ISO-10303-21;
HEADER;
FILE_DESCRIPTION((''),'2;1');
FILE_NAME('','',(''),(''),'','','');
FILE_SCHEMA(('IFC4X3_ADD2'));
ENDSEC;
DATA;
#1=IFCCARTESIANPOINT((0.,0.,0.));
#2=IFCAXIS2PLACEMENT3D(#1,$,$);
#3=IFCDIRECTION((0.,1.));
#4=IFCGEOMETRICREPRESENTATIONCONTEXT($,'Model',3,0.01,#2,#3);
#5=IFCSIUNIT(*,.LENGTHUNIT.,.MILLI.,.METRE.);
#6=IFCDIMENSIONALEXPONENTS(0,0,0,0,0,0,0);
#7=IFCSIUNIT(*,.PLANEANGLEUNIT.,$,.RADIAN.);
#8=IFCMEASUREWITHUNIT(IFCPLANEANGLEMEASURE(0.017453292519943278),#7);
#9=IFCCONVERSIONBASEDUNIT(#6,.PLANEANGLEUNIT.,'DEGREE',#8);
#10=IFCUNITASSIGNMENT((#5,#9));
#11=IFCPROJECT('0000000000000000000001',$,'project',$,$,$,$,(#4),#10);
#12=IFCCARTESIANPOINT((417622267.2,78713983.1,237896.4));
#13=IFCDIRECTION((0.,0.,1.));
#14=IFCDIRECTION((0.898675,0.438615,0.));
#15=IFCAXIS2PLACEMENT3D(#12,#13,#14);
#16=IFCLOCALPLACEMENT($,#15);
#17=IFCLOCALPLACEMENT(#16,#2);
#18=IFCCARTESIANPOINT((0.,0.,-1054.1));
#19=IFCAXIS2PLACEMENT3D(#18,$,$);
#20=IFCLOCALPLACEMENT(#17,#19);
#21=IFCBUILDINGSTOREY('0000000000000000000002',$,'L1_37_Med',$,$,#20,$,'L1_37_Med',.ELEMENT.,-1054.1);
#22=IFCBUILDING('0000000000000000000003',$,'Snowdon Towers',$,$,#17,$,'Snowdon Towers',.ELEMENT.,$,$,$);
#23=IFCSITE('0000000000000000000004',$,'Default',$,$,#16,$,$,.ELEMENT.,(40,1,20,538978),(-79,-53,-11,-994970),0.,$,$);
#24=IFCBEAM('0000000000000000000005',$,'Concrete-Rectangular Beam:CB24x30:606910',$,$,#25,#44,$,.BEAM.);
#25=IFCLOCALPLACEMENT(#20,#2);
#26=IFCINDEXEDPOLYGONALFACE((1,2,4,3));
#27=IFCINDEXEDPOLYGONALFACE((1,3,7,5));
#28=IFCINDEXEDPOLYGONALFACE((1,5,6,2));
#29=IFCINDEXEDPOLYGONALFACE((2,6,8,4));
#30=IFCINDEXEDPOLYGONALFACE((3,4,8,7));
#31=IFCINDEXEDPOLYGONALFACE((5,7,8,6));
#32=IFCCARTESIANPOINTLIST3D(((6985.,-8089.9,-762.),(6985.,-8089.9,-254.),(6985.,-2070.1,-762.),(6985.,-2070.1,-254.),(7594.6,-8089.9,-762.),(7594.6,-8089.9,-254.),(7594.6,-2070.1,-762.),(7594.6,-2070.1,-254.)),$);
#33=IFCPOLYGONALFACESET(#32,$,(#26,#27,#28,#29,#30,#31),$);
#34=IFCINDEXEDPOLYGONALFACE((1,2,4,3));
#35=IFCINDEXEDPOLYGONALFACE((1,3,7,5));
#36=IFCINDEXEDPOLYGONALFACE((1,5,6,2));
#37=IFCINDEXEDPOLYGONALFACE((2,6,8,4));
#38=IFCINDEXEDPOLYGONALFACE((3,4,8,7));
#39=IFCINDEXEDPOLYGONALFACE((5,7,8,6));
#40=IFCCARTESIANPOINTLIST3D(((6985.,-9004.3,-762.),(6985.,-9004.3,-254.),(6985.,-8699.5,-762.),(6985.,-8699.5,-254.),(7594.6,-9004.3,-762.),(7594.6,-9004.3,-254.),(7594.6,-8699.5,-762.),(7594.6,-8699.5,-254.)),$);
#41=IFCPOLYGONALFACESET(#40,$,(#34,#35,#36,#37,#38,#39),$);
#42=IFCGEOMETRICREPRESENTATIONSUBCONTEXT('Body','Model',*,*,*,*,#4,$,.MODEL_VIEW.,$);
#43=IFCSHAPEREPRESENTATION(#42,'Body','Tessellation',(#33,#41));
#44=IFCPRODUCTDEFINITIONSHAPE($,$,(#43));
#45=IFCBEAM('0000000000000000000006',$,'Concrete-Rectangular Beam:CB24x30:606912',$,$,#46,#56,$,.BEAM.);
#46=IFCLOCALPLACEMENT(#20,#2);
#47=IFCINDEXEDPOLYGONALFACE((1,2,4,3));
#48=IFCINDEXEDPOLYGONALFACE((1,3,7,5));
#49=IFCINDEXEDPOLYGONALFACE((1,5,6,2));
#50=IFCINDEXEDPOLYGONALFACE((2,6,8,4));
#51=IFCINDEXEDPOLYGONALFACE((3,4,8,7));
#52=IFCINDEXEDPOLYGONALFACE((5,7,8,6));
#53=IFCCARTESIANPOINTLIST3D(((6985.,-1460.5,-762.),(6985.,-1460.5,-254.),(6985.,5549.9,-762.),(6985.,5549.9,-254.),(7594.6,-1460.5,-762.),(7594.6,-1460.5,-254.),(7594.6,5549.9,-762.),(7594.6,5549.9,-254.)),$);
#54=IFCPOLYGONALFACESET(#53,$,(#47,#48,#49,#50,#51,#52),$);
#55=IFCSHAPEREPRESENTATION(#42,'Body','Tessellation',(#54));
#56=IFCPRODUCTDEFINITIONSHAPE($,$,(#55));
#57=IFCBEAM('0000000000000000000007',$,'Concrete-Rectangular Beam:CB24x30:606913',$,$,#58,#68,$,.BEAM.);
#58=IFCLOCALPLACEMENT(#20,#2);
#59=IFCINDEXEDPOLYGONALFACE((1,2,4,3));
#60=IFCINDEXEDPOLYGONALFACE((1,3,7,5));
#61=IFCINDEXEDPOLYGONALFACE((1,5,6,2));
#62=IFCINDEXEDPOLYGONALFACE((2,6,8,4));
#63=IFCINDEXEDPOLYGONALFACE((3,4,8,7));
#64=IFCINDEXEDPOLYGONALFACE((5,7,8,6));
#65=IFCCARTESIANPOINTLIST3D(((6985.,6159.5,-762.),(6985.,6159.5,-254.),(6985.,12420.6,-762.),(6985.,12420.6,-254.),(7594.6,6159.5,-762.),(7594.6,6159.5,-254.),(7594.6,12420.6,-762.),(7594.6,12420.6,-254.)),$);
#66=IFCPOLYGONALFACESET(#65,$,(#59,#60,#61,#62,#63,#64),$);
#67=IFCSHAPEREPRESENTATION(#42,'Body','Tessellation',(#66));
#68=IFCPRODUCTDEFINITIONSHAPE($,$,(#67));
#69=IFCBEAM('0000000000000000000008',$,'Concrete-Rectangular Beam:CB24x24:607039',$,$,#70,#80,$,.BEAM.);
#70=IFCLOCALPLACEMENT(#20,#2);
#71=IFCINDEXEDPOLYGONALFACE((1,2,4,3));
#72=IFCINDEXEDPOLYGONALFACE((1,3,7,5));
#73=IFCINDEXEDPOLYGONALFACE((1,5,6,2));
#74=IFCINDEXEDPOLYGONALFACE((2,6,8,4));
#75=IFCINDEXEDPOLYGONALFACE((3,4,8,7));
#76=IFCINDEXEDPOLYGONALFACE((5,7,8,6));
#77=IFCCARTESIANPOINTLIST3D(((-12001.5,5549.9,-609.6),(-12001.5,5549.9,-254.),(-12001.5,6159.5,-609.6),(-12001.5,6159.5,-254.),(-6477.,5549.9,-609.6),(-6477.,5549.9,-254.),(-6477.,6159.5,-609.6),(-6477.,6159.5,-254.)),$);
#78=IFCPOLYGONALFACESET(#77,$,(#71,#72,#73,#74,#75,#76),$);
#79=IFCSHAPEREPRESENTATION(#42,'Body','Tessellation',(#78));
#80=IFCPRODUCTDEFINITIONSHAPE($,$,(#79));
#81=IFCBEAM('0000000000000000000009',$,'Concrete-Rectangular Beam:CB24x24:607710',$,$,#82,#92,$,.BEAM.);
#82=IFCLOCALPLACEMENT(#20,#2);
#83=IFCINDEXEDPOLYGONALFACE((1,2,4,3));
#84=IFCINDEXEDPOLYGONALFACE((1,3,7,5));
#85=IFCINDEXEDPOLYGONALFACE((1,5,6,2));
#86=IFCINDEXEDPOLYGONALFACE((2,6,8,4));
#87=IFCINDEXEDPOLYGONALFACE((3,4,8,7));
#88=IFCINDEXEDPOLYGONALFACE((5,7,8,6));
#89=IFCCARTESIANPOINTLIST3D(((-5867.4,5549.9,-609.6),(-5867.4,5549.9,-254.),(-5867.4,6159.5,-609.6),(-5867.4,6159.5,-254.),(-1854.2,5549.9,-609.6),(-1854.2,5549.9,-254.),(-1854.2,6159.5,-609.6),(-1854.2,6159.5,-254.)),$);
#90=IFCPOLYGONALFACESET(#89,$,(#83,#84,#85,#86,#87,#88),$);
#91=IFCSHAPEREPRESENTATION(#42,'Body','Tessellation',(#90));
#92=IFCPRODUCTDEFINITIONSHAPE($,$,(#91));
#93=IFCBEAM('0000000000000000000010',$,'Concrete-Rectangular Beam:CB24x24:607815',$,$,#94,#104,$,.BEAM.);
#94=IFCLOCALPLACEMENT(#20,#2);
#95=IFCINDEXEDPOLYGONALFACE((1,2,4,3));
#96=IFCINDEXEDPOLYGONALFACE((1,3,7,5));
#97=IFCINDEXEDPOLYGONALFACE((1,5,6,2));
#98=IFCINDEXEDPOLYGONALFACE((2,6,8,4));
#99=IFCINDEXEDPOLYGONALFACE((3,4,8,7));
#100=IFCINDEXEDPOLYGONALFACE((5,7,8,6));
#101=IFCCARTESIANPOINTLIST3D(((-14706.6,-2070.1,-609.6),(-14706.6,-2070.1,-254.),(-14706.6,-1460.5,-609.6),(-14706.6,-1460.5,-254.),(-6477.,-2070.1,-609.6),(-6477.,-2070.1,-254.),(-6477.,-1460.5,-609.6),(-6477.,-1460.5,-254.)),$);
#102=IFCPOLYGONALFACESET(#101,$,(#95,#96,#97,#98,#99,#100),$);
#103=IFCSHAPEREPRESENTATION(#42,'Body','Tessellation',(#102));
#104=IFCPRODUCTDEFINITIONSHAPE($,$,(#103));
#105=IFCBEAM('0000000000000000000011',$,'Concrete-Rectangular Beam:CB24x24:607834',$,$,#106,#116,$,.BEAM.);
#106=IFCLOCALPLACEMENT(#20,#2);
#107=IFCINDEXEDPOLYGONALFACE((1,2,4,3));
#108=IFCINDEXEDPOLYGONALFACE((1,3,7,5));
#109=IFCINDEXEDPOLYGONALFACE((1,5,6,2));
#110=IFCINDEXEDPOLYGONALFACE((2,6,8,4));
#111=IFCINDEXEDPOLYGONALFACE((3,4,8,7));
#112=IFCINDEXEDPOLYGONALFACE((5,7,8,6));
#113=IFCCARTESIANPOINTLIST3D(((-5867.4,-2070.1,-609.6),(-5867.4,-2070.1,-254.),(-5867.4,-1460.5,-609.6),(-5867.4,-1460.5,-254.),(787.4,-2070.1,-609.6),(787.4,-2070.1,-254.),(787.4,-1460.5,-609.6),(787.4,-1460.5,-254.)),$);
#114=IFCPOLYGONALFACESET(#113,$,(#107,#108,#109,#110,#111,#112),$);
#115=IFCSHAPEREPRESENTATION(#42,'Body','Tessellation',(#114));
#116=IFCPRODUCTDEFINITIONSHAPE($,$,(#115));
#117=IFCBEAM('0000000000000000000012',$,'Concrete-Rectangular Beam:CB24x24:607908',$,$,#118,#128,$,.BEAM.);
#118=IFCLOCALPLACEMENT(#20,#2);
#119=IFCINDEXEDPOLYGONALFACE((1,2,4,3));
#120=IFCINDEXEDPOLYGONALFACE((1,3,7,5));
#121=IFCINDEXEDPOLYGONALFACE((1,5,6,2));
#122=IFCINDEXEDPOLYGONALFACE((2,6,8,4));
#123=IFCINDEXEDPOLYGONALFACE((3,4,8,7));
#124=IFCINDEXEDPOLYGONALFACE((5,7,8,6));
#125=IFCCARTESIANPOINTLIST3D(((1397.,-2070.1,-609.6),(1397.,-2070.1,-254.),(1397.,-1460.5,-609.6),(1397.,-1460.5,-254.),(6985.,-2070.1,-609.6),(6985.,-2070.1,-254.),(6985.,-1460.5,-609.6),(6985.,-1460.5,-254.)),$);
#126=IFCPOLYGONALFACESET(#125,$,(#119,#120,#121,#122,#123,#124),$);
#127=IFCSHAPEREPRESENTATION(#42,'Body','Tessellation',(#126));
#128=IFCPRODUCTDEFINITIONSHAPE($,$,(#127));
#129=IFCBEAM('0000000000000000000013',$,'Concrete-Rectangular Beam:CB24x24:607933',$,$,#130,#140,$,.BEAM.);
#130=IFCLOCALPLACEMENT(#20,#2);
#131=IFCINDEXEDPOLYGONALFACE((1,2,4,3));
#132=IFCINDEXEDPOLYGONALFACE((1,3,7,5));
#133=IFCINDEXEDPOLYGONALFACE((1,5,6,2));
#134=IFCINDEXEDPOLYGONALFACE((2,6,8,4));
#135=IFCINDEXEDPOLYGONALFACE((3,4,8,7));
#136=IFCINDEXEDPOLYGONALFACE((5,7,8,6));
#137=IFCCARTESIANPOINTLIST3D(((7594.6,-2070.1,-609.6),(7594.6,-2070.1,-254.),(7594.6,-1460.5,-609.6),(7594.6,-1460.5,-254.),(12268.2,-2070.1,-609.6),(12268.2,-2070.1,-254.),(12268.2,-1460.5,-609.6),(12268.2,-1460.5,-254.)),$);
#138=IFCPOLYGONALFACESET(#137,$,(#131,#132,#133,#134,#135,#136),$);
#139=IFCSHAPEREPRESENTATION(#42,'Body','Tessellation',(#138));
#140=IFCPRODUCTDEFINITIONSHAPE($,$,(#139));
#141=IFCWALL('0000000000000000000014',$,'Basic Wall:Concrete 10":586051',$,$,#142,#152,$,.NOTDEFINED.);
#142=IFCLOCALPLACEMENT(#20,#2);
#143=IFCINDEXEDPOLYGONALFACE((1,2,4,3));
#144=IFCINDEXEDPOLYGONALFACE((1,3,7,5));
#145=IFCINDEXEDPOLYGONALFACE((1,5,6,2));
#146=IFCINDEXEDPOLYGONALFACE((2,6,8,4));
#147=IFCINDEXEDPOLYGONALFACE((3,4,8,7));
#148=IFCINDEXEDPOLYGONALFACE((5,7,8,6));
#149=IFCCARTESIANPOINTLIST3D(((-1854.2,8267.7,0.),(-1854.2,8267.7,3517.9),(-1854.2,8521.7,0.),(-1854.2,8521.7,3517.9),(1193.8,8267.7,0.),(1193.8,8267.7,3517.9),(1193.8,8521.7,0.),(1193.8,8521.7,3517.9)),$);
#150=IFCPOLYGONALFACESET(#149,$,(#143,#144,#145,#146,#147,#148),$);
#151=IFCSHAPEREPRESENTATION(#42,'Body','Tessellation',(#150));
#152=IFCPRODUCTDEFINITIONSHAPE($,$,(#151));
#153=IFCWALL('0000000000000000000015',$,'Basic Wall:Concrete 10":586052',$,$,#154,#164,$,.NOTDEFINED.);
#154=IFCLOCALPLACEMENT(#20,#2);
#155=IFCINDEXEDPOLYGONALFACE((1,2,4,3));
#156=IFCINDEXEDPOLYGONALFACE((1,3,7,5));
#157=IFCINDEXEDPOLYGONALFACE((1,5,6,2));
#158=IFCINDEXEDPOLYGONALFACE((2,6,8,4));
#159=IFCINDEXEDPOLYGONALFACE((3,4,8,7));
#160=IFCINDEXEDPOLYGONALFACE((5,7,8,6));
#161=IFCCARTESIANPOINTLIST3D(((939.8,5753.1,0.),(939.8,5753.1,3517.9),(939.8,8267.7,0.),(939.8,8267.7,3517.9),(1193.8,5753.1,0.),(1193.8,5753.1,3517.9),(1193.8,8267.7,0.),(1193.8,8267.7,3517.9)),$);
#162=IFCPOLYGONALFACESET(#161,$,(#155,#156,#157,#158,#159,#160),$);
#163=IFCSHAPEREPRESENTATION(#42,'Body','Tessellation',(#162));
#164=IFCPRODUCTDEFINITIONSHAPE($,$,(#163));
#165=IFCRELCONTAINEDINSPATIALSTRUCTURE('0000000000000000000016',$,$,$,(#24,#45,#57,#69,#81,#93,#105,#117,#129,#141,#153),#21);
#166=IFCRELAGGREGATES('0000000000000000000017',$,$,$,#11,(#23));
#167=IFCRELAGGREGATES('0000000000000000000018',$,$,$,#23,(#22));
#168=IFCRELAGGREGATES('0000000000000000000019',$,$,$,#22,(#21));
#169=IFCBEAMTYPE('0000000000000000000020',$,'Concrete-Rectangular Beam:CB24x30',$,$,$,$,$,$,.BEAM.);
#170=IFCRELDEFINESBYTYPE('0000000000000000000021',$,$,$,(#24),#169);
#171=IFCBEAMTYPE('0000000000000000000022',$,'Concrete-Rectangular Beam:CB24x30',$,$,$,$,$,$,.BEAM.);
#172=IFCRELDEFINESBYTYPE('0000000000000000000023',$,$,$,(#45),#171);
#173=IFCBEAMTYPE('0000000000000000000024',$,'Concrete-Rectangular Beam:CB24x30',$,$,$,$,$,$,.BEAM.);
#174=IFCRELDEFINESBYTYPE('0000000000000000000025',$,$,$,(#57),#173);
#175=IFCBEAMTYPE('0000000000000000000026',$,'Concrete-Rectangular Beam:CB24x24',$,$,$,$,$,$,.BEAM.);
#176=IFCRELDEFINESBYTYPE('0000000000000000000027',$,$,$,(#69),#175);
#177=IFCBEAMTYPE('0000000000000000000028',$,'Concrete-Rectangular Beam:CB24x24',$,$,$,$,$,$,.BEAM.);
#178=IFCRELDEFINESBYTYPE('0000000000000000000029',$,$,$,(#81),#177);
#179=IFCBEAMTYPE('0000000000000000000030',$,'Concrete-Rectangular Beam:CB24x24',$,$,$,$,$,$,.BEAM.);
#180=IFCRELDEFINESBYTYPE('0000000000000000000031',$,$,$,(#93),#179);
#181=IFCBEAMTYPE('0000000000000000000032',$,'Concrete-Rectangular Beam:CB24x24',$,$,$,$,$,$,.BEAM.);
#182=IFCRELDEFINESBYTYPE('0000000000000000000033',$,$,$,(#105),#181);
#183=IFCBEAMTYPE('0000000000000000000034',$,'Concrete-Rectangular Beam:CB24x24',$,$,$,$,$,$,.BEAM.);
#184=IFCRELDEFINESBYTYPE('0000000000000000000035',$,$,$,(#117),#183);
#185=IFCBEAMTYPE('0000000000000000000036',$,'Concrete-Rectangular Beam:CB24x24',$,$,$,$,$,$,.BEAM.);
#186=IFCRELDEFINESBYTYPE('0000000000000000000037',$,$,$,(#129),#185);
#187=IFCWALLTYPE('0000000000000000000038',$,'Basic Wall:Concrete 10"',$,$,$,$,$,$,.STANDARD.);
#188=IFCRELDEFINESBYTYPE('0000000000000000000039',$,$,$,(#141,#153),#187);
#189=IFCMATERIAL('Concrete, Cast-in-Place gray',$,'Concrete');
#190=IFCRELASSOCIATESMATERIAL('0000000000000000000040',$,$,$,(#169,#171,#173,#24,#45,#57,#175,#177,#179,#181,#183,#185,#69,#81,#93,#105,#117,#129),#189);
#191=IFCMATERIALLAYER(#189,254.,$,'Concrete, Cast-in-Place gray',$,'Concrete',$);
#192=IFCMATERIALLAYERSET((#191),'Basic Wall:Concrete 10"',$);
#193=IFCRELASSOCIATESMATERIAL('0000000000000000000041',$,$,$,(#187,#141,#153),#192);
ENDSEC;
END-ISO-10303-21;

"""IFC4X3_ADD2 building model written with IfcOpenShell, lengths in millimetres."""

from ifc_helpers import new_model, entity, si_unit, converted_unit, direction, frame, frame_2d, origin, origin_2d_with_axis, place, context, subcontext, project, spatial, rectangle, extrude, source, transform, mapped, material, layer, layer_set, material_profile, profile_set, profile_usage, type_object, type_shapes, element, save


model = new_model("IFC4X3_ADD2")

# Units and contexts
model_context = context("Model", 3, precision=0.01, world=origin(), true_north=direction((0.0, 1.0)))
body_context = subcontext(model_context, "Body", "Model", "MODEL_VIEW")
ifc_project = project(units=[si_unit("LENGTHUNIT", "METRE", prefix="MILLI"), converted_unit("PLANEANGLEUNIT", "DEGREE", entity("IfcPlaneAngleMeasure", 0.017453292519943278), si_unit("PLANEANGLEUNIT", "RADIAN"), dimensions=[0, 0, 0, 0, 0, 0, 0])], contexts=[model_context])

# Site, building, storey
site_placement = place(None, frame((417622267.2, 78713983.1, 237896.4), z_axis=(0.0, 0.0, 1.0), x_axis=(0.898675, 0.438615, 0.0)))
site = spatial("IfcSite", under=ifc_project, at=site_placement, Name="Default", CompositionType="ELEMENT", RefLatitude=(40, 1, 20, 538978), RefLongitude=(-79, -53, -11, -994970), RefElevation=0.0)
building_placement = place(site_placement, origin())
building = spatial("IfcBuilding", under=site, at=building_placement, Name="Snowdon Towers", LongName="Snowdon Towers", CompositionType="ELEMENT")
storey_placement = place(building_placement, frame((0.0, 0.0, -1054.1)))
storey = spatial("IfcBuildingStorey", under=building, at=storey_placement, Name="L1_37_Med", LongName="L1_37_Med", CompositionType="ELEMENT", Elevation=-1054.1)

# Beams
ifc_material_1 = material(Name="Concrete, Cast-in-Place gray", Category="Concrete")
ifc_material_profile_1 = material_profile(ifc_material_1, rectangle(XDim=508.0, YDim=609.6, at=frame_2d((0.0, 0.0), x_axis=(0.0, 1.0))), Name="CB24x30")
ifc_profile_set_1 = profile_set([ifc_material_profile_1], Name="CB24x30")
ifc_profile_usage_1 = profile_usage(ifc_profile_set_1, cardinal=8)
beam_type_1 = type_object("IfcBeamType", Name="Concrete-Rectangular Beam:CB24x30", PredefinedType="BEAM", material=ifc_profile_set_1)
shared_shape_1 = source(origin(), body_context, "Body", "SweptSolid", [
    extrude(rectangle(XDim=508.0, YDim=609.6, at=frame_2d((0.0, 0.0), x_axis=(0.0, 1.0))), frame((7289.8, -8089.9, -1562.1), z_axis=(0.0, 1.0, 0.0), x_axis=(-1.0, 0.0, 0.0)), (0.0, 0.0, 1.0), 6019.8),
    extrude(rectangle(XDim=508.0, YDim=609.6, at=frame_2d((0.0, 0.0), x_axis=(0.0, 1.0))), frame((7289.8, -9004.3, -1562.1), z_axis=(0.0, 1.0, 0.0), x_axis=(-1.0, 0.0, 0.0)), (0.0, 0.0, 1.0), 304.8),
])
type_shapes(beam_type_1, [shared_shape_1])
beam_1_placement = place(storey_placement, frame((0.0, 0.0, 1054.1)))
element("IfcBeam", 1, at=beam_1_placement, inside=storey, type_object=beam_type_1, material=ifc_profile_usage_1, Name="Concrete-Rectangular Beam:CB24x30:606910", PredefinedType="BEAM", context=body_context, shape_type="MappedRepresentation", body=[
    mapped(shared_shape_1, transform((0.0, 0.0, 0.0), scale=1.0)),
])
beam_type_2 = type_object("IfcBeamType", Name="Concrete-Rectangular Beam:CB24x30", PredefinedType="BEAM", material=ifc_profile_set_1)
shared_shape_2 = source(origin(), body_context, "Body", "SweptSolid", [
    extrude(rectangle(XDim=508.0, YDim=609.6, at=frame_2d((0.0, 0.0), x_axis=(0.0, 1.0))), frame((7289.8, -1460.5, -1562.1), z_axis=(0.0, 1.0, 0.0), x_axis=(-1.0, 0.0, 0.0)), (0.0, 0.0, 1.0), 7010.4),
])
type_shapes(beam_type_2, [shared_shape_2])
beam_2_placement = place(storey_placement, frame((0.0, 0.0, 1054.1)))
element("IfcBeam", 2, at=beam_2_placement, inside=storey, type_object=beam_type_2, material=ifc_profile_usage_1, Name="Concrete-Rectangular Beam:CB24x30:606912", PredefinedType="BEAM", context=body_context, shape_type="MappedRepresentation", body=[
    mapped(shared_shape_2, transform((0.0, 0.0, 0.0), scale=1.0)),
])
beam_type_3 = type_object("IfcBeamType", Name="Concrete-Rectangular Beam:CB24x30", PredefinedType="BEAM", material=ifc_profile_set_1)
shared_shape_3 = source(origin(), body_context, "Body", "SweptSolid", [
    extrude(rectangle(XDim=508.0, YDim=609.6, at=frame_2d((0.0, 0.0), x_axis=(0.0, 1.0))), frame((7289.8, 6159.5, -1562.1), z_axis=(0.0, 1.0, 0.0), x_axis=(-1.0, 0.0, 0.0)), (0.0, 0.0, 1.0), 6261.1),
])
type_shapes(beam_type_3, [shared_shape_3])
beam_3_placement = place(storey_placement, frame((0.0, 0.0, 1054.1)))
element("IfcBeam", 3, at=beam_3_placement, inside=storey, type_object=beam_type_3, material=ifc_profile_usage_1, Name="Concrete-Rectangular Beam:CB24x30:606913", PredefinedType="BEAM", context=body_context, shape_type="MappedRepresentation", body=[
    mapped(shared_shape_3, transform((0.0, 0.0, 0.0), scale=1.0)),
])
ifc_material_profile_2 = material_profile(ifc_material_1, rectangle(XDim=355.6, YDim=609.6, at=frame_2d((0.0, 0.0), x_axis=(1.0, 0.0))), Name="CB24x24")
ifc_profile_set_2 = profile_set([ifc_material_profile_2], Name="CB24x24")
ifc_profile_usage_2 = profile_usage(ifc_profile_set_2, cardinal=8)
beam_type_4 = type_object("IfcBeamType", Name="Concrete-Rectangular Beam:CB24x24", PredefinedType="BEAM", material=ifc_profile_set_2)
shared_shape_4 = source(origin(), body_context, "Body", "SweptSolid", [
    extrude(rectangle(XDim=355.6, YDim=609.6, at=frame_2d((0.0, 0.0), x_axis=(1.0, 0.0))), frame((-12001.5, 5854.7, -1485.9), z_axis=(1.0, 0.0, 0.0), x_axis=(0.0, 0.0, -1.0)), (0.0, 0.0, 1.0), 5524.5),
])
type_shapes(beam_type_4, [shared_shape_4])
beam_4_placement = place(storey_placement, frame((0.0, 0.0, 1054.1)))
element("IfcBeam", 4, at=beam_4_placement, inside=storey, type_object=beam_type_4, material=ifc_profile_usage_2, Name="Concrete-Rectangular Beam:CB24x24:607039", PredefinedType="BEAM", context=body_context, shape_type="MappedRepresentation", body=[
    mapped(shared_shape_4, transform((0.0, 0.0, 0.0), scale=1.0)),
])
beam_type_5 = type_object("IfcBeamType", Name="Concrete-Rectangular Beam:CB24x24", PredefinedType="BEAM", material=ifc_profile_set_2)
shared_shape_5 = source(origin(), body_context, "Body", "SweptSolid", [
    extrude(rectangle(XDim=355.6, YDim=609.6, at=origin_2d_with_axis()), frame((-5867.4, 5854.7, -1485.9), z_axis=(1.0, 0.0, 0.0), x_axis=(0.0, 0.0, -1.0)), (0.0, 0.0, 1.0), 4013.2),
])
type_shapes(beam_type_5, [shared_shape_5])
beam_5_placement = place(storey_placement, frame((0.0, 0.0, 1054.1)))
element("IfcBeam", 5, at=beam_5_placement, inside=storey, type_object=beam_type_5, material=ifc_profile_usage_2, Name="Concrete-Rectangular Beam:CB24x24:607710", PredefinedType="BEAM", context=body_context, shape_type="MappedRepresentation", body=[
    mapped(shared_shape_5, transform((0.0, 0.0, 0.0), scale=1.0)),
])
beam_type_6 = type_object("IfcBeamType", Name="Concrete-Rectangular Beam:CB24x24", PredefinedType="BEAM", material=ifc_profile_set_2)
shared_shape_6 = source(origin(), body_context, "Body", "SweptSolid", [
    extrude(rectangle(XDim=355.6, YDim=609.6, at=frame_2d((0.0, 0.0), x_axis=(1.0, 0.0))), frame((-14706.6, -1765.3, -1485.9), z_axis=(1.0, 0.0, 0.0), x_axis=(0.0, 0.0, -1.0)), (0.0, 0.0, 1.0), 8229.6),
])
type_shapes(beam_type_6, [shared_shape_6])
beam_6_placement = place(storey_placement, frame((0.0, 0.0, 1054.1)))
element("IfcBeam", 6, at=beam_6_placement, inside=storey, type_object=beam_type_6, material=ifc_profile_usage_2, Name="Concrete-Rectangular Beam:CB24x24:607815", PredefinedType="BEAM", context=body_context, shape_type="MappedRepresentation", body=[
    mapped(shared_shape_6, transform((0.0, 0.0, 0.0), scale=1.0)),
])
beam_type_7 = type_object("IfcBeamType", Name="Concrete-Rectangular Beam:CB24x24", PredefinedType="BEAM", material=ifc_profile_set_2)
shared_shape_7 = source(origin(), body_context, "Body", "SweptSolid", [
    extrude(rectangle(XDim=355.6, YDim=609.6, at=origin_2d_with_axis()), frame((-5867.4, -1765.3, -1485.9), z_axis=(1.0, 0.0, 0.0), x_axis=(0.0, 0.0, -1.0)), (0.0, 0.0, 1.0), 6654.8),
])
type_shapes(beam_type_7, [shared_shape_7])
beam_7_placement = place(storey_placement, frame((0.0, 0.0, 1054.1)))
element("IfcBeam", 7, at=beam_7_placement, inside=storey, type_object=beam_type_7, material=ifc_profile_usage_2, Name="Concrete-Rectangular Beam:CB24x24:607834", PredefinedType="BEAM", context=body_context, shape_type="MappedRepresentation", body=[
    mapped(shared_shape_7, transform((0.0, 0.0, 0.0), scale=1.0)),
])
beam_type_8 = type_object("IfcBeamType", Name="Concrete-Rectangular Beam:CB24x24", PredefinedType="BEAM", material=ifc_profile_set_2)
shared_shape_8 = source(origin(), body_context, "Body", "SweptSolid", [
    extrude(rectangle(XDim=355.6, YDim=609.6, at=frame_2d((0.0, 0.0), x_axis=(1.0, 0.0))), frame((1397.0, -1765.3, -1485.9), z_axis=(1.0, 0.0, 0.0), x_axis=(0.0, 0.0, -1.0)), (0.0, 0.0, 1.0), 5588.0),
])
type_shapes(beam_type_8, [shared_shape_8])
beam_8_placement = place(storey_placement, frame((0.0, 0.0, 1054.1)))
element("IfcBeam", 8, at=beam_8_placement, inside=storey, type_object=beam_type_8, material=ifc_profile_usage_2, Name="Concrete-Rectangular Beam:CB24x24:607908", PredefinedType="BEAM", context=body_context, shape_type="MappedRepresentation", body=[
    mapped(shared_shape_8, transform((0.0, 0.0, 0.0), scale=1.0)),
])
beam_type_9 = type_object("IfcBeamType", Name="Concrete-Rectangular Beam:CB24x24", PredefinedType="BEAM", material=ifc_profile_set_2)
shared_shape_9 = source(origin(), body_context, "Body", "SweptSolid", [
    extrude(rectangle(XDim=355.6, YDim=609.6, at=frame_2d((0.0, 0.0), x_axis=(1.0, 0.0))), frame((7594.6, -1765.3, -1485.9), z_axis=(1.0, 0.0, 0.0), x_axis=(0.0, 0.0, -1.0)), (0.0, 0.0, 1.0), 4673.6),
])
type_shapes(beam_type_9, [shared_shape_9])
beam_9_placement = place(storey_placement, frame((0.0, 0.0, 1054.1)))
element("IfcBeam", 9, at=beam_9_placement, inside=storey, type_object=beam_type_9, material=ifc_profile_usage_2, Name="Concrete-Rectangular Beam:CB24x24:607933", PredefinedType="BEAM", context=body_context, shape_type="MappedRepresentation", body=[
    mapped(shared_shape_9, transform((0.0, 0.0, 0.0), scale=1.0)),
])

# Walls
ifc_layer_1 = layer(ifc_material_1, 254.0, Name="Concrete, Cast-in-Place gray", Category="Concrete")
ifc_layer_set_1 = layer_set([ifc_layer_1], Name="Basic Wall:Concrete 10\"")
wall_type_1 = type_object("IfcWallType", Name="Basic Wall:Concrete 10\"", PredefinedType="STANDARD", material=ifc_layer_set_1)
wall_1_placement = place(storey_placement, frame((-1854.2, 8394.7, 0.0)))
element("IfcWall", 10, at=wall_1_placement, inside=storey, type_object=wall_type_1, material=ifc_layer_set_1, Name="Basic Wall:Concrete 10\":586051", PredefinedType="NOTDEFINED", context=body_context, shape_type="SweptSolid", body=[
    extrude(rectangle(XDim=3048.0, YDim=254.0, at=frame_2d((1524.0, 0.0), x_axis=(-1.0, 0.0))), origin(), (0.0, 0.0, 1.0), 3517.9),
])
wall_2_placement = place(storey_placement, frame((1066.8, 8267.7, 0.0), z_axis=(0.0, 0.0, 1.0), x_axis=(0.0, -1.0, 0.0)))
element("IfcWall", 11, at=wall_2_placement, inside=storey, type_object=wall_type_1, material=ifc_layer_set_1, Name="Basic Wall:Concrete 10\":586052", PredefinedType="NOTDEFINED", context=body_context, shape_type="SweptSolid", body=[
    extrude(rectangle(XDim=2514.6, YDim=254.0, at=frame_2d((1257.3, 0.0), x_axis=(-1.0, 0.0))), origin(), (0.0, 0.0, 1.0), 3517.9),
])

save(model, "model.ifc")
